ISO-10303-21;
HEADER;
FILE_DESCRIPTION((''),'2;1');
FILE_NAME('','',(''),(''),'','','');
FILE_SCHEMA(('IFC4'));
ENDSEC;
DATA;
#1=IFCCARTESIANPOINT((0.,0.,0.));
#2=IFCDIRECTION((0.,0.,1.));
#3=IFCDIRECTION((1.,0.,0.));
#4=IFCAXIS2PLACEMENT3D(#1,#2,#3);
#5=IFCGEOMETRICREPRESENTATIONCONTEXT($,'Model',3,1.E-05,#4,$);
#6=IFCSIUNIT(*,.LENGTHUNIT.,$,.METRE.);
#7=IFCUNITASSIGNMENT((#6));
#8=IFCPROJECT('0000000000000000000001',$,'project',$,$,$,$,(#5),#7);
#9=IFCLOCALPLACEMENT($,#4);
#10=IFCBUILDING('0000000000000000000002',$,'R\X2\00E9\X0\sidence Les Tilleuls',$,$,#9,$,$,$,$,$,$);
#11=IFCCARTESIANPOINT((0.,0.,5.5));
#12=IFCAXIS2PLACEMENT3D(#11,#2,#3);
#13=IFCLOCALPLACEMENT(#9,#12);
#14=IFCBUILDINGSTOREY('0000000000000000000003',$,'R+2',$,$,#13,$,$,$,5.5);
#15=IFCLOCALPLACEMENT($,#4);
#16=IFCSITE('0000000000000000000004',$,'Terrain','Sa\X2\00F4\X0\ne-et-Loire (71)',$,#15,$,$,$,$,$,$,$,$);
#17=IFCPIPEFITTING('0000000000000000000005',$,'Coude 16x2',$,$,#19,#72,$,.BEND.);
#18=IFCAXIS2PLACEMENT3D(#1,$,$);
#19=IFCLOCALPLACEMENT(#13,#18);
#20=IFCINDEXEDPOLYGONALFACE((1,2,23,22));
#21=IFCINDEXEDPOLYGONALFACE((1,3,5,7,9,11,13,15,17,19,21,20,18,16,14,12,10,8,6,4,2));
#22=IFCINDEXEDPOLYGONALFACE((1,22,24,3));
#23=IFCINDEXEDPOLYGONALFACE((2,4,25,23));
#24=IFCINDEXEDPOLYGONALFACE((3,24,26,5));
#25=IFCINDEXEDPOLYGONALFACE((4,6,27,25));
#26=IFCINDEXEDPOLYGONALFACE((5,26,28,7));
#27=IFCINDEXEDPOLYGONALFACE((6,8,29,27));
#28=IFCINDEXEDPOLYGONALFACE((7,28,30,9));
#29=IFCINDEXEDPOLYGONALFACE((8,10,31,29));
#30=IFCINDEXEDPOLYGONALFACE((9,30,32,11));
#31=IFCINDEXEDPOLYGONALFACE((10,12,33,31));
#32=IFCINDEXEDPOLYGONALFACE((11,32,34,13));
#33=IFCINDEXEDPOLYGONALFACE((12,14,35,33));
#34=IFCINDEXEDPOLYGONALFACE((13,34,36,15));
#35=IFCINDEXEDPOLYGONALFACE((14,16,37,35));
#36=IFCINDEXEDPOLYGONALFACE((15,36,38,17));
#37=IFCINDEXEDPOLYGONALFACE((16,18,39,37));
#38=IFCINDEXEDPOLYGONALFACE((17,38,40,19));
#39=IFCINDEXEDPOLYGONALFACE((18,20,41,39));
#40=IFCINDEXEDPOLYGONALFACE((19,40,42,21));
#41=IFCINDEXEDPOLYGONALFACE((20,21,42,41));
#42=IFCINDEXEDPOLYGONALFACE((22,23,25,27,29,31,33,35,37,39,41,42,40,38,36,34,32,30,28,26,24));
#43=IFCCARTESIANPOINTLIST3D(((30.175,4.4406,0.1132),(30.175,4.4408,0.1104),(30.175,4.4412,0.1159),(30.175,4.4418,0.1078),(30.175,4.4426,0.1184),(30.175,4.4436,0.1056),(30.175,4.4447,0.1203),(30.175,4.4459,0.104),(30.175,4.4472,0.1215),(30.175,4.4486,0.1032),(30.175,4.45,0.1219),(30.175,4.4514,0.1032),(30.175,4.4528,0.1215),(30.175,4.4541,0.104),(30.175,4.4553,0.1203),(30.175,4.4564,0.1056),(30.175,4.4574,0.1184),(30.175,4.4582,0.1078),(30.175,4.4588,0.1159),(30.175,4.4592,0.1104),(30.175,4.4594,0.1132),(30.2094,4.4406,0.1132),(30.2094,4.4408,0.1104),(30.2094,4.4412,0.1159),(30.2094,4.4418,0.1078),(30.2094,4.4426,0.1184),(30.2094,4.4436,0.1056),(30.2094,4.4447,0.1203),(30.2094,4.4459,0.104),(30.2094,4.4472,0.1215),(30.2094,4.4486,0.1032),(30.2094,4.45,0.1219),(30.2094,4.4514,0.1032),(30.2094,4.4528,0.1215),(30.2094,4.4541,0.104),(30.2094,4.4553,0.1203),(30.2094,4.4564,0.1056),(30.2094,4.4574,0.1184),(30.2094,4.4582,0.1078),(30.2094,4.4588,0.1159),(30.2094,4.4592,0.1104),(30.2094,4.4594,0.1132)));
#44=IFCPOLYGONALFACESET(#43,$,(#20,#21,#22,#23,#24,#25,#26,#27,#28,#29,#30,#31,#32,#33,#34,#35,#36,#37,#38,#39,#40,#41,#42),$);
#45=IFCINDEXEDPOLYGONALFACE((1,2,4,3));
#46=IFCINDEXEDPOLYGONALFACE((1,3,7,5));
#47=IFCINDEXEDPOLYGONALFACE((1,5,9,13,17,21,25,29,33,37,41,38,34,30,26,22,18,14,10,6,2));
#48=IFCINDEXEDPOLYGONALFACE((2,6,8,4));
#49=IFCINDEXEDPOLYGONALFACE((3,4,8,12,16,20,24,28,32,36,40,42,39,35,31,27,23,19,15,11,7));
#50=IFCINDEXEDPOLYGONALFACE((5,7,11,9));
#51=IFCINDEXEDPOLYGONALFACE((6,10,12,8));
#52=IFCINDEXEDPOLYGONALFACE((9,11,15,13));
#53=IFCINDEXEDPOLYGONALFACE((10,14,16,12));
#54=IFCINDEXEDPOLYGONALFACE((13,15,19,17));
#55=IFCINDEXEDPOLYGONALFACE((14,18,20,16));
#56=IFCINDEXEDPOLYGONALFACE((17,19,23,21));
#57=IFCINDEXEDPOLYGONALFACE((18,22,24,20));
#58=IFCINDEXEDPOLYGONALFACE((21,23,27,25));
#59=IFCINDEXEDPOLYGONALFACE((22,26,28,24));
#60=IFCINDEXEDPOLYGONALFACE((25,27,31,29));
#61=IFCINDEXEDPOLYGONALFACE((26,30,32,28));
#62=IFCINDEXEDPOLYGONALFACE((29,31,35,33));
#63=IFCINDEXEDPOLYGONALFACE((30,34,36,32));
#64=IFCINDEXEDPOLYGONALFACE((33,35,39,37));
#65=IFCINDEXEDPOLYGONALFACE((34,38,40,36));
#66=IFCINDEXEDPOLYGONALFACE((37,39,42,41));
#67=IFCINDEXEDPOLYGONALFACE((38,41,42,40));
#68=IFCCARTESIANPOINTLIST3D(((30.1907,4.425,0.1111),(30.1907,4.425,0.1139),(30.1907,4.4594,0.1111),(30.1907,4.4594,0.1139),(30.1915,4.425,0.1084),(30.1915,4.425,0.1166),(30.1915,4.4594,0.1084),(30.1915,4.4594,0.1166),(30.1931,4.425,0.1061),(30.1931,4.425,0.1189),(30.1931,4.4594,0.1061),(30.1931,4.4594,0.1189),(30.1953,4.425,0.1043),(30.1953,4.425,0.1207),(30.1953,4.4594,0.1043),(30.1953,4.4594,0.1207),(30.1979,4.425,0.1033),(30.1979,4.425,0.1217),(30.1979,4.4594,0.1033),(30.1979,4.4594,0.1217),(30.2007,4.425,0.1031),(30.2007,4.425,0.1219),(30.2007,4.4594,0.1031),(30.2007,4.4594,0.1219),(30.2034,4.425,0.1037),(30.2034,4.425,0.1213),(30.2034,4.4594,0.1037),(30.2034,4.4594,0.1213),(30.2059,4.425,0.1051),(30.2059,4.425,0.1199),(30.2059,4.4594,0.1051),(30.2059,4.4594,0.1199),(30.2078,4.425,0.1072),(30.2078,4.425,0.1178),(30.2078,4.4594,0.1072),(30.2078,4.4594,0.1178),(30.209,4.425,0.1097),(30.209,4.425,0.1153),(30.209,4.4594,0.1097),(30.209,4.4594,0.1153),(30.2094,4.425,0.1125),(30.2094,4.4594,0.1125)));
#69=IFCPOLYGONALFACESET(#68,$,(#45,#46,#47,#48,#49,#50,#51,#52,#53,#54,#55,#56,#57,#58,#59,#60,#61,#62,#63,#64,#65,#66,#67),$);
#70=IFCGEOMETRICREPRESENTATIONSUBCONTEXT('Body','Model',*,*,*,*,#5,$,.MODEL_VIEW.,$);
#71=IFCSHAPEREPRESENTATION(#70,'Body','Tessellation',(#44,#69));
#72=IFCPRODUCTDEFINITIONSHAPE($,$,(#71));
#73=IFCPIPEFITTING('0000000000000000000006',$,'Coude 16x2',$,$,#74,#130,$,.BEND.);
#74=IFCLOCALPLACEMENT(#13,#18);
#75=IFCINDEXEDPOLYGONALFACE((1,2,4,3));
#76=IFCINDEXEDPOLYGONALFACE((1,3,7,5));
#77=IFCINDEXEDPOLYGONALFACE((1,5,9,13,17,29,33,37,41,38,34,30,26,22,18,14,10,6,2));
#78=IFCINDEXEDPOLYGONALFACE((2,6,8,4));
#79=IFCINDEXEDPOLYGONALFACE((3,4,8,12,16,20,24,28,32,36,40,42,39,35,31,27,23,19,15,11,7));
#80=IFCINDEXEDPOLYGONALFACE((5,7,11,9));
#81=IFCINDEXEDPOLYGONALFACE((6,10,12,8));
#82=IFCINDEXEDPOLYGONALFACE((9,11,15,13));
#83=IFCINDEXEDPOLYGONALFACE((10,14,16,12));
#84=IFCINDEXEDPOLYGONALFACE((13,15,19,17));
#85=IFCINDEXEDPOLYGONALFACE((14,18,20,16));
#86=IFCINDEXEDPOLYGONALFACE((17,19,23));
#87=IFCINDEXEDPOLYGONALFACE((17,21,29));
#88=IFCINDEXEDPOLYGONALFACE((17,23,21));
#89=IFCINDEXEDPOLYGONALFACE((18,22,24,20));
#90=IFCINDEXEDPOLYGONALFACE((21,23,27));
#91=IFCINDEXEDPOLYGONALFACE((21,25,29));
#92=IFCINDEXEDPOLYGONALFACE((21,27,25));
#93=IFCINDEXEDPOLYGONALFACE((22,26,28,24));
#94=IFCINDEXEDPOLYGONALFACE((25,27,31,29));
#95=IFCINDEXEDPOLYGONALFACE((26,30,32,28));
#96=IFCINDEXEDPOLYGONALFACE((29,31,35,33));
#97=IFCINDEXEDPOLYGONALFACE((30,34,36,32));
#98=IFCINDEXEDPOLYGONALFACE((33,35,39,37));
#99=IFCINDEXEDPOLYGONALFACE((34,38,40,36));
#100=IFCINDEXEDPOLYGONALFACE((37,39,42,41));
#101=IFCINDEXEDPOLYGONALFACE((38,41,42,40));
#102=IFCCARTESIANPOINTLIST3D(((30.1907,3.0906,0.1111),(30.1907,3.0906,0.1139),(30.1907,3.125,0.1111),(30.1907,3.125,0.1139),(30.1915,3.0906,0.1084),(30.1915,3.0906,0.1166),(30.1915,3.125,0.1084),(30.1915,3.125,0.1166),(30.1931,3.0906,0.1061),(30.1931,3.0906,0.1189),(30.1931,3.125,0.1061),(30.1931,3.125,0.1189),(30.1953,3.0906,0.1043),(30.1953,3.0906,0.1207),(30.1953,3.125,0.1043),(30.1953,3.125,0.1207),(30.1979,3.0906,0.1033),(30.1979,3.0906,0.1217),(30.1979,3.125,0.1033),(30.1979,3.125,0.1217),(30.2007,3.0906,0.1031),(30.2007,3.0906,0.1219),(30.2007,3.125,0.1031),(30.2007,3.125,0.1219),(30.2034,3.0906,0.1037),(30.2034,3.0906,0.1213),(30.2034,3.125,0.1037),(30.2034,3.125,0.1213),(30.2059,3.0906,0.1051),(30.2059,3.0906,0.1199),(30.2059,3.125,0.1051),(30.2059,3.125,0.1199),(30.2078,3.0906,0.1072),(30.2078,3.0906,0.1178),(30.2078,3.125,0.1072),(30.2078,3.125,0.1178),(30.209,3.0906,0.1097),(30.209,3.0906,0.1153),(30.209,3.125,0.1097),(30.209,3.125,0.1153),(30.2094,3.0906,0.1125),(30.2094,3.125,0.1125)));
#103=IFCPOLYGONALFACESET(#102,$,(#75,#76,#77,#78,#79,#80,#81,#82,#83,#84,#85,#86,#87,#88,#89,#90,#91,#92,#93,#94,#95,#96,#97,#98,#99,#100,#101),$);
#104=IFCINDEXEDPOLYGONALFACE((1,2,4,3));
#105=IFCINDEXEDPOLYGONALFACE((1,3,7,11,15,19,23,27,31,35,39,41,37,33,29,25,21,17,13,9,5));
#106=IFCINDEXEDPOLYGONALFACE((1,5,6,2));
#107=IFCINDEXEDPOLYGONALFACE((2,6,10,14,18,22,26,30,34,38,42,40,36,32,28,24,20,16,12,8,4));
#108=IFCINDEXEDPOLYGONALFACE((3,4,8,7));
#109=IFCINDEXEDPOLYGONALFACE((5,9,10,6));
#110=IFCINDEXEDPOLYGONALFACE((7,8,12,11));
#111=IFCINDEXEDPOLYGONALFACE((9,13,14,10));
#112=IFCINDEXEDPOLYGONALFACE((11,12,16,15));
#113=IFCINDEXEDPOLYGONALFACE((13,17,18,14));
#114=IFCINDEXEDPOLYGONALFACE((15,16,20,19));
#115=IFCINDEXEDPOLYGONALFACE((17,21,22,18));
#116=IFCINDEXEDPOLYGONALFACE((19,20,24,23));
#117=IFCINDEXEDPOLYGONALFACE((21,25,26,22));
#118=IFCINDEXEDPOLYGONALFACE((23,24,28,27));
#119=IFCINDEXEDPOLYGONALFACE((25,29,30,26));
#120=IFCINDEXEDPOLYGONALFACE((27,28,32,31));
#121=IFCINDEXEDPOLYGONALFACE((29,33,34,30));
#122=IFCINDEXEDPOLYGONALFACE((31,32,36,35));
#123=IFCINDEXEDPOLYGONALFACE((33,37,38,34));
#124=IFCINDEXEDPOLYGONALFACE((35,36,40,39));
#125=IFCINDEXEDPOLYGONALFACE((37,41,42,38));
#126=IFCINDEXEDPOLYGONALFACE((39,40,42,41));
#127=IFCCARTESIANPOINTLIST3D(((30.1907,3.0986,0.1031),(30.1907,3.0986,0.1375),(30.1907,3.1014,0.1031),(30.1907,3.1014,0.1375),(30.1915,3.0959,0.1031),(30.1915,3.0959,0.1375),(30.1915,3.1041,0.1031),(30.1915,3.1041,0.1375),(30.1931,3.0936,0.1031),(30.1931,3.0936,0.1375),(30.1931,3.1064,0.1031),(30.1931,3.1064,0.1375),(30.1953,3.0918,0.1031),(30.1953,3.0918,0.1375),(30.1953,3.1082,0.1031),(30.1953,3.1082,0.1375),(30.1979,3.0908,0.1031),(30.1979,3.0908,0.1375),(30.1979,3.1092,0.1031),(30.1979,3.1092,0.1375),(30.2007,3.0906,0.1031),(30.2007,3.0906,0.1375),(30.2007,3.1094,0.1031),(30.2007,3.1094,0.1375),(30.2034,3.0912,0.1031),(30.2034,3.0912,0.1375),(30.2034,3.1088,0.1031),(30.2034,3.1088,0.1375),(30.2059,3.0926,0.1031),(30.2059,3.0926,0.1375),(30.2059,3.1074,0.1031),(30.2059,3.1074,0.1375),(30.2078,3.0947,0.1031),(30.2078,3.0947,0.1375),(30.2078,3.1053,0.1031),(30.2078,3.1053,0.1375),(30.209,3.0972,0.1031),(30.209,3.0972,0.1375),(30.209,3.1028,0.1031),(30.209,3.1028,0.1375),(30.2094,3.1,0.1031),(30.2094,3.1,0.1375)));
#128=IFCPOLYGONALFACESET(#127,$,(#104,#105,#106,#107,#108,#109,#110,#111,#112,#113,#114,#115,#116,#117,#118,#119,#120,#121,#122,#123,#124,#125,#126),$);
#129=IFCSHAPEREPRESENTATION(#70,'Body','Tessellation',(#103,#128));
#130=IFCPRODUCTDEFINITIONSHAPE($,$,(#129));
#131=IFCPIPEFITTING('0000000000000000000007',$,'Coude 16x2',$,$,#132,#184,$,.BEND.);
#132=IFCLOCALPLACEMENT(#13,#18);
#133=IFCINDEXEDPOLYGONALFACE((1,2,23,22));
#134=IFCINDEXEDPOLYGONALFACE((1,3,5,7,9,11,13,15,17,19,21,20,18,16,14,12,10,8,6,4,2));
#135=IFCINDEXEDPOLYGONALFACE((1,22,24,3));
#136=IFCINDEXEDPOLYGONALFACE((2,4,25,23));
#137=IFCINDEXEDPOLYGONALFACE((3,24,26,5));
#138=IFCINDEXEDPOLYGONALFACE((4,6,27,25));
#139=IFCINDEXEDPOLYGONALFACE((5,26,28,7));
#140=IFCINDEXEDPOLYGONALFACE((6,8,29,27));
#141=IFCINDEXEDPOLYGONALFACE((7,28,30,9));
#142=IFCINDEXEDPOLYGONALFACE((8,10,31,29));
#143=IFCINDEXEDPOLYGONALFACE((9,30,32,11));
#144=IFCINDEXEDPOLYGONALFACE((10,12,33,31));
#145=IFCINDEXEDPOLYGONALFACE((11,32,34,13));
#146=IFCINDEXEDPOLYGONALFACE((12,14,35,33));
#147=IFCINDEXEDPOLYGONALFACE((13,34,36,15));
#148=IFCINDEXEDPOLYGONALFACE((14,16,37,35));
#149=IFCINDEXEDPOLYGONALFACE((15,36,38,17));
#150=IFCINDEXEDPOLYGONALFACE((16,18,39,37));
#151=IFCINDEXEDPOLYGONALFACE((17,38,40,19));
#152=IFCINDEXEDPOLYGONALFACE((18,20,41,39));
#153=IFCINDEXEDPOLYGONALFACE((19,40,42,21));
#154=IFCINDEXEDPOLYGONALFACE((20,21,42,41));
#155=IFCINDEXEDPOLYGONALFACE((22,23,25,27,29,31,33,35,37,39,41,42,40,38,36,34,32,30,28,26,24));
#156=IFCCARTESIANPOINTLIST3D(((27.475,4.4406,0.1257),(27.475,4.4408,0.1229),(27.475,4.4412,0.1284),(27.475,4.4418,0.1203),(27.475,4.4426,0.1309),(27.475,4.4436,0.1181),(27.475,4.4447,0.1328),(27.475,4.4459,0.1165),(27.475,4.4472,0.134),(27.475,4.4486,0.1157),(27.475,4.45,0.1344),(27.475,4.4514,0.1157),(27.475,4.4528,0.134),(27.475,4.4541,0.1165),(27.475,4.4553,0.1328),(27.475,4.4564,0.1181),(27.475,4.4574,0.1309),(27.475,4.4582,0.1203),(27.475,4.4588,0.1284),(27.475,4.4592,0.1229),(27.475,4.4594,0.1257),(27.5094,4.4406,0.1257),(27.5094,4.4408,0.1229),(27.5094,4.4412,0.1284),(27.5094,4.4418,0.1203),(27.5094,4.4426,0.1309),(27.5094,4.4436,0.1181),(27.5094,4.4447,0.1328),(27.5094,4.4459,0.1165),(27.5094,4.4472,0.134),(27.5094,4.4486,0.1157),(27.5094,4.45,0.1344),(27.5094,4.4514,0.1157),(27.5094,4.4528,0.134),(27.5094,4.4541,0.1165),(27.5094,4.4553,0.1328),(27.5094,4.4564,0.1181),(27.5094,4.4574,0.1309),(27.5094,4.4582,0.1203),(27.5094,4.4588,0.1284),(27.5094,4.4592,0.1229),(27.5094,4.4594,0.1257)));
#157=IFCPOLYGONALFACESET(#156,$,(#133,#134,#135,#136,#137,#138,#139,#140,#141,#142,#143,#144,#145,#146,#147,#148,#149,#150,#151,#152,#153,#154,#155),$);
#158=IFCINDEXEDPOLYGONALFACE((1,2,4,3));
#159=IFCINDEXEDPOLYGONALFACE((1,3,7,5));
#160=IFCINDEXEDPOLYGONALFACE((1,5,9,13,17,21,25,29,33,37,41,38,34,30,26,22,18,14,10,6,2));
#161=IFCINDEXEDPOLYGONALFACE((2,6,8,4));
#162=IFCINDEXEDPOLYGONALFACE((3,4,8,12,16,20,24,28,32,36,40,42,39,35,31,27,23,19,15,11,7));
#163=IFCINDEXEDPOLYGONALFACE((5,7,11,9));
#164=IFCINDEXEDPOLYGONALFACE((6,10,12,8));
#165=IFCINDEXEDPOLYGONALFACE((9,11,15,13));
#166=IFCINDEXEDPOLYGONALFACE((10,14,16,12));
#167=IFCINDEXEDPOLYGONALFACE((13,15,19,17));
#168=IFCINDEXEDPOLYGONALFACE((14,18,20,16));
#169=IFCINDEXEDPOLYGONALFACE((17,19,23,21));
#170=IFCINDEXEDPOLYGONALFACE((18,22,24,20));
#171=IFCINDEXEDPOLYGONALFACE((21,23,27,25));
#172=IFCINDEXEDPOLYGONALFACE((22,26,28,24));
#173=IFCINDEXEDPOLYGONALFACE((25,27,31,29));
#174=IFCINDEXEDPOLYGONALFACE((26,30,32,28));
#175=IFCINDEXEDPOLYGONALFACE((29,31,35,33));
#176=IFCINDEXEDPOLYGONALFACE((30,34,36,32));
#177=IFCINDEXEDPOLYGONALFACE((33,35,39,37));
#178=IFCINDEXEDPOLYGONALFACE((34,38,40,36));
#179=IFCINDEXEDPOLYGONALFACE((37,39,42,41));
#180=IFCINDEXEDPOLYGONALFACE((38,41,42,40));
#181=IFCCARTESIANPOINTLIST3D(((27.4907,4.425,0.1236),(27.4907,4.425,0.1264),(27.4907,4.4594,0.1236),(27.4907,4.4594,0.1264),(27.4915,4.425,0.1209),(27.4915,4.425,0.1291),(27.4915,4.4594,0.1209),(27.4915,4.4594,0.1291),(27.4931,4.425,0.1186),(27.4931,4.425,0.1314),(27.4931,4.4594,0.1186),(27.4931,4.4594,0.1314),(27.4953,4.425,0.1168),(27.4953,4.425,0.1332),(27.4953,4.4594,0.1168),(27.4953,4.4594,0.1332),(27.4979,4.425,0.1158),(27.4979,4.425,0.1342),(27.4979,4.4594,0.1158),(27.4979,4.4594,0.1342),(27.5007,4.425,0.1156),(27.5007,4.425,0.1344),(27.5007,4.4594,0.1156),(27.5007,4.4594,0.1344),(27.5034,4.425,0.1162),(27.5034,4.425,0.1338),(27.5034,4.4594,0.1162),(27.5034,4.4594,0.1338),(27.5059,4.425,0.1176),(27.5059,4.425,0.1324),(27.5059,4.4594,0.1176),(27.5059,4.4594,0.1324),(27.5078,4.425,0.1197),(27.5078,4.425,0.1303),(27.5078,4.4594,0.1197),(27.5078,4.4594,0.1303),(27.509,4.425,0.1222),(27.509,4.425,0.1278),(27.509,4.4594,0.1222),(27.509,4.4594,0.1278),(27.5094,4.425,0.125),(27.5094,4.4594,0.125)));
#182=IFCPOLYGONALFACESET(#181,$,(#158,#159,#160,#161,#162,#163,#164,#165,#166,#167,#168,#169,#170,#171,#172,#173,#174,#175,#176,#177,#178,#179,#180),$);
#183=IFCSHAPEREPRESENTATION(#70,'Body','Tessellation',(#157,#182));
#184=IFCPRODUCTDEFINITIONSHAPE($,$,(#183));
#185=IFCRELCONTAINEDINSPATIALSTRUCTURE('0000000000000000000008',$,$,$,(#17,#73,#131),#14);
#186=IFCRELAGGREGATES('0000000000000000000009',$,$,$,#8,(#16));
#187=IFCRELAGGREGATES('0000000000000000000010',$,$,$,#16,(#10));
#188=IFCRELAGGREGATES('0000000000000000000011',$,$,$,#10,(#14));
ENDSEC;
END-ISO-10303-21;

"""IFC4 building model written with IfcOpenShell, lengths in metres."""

from ifc_helpers import new_model, si_unit, frame, origin_with_axes, place, context, subcontext, project, spatial, circle, extrude, element, save


model = new_model("IFC4")

# Units and contexts
model_context = context("Model", 3, precision=1e-05, world=origin_with_axes())
body_context = subcontext(model_context, "Body", "Model", "MODEL_VIEW")
ifc_project = project(units=[si_unit("LENGTHUNIT", "METRE")], contexts=[model_context])

# Site, building, storey
site_placement = place(None, origin_with_axes())
site = spatial("IfcSite", under=ifc_project, at=site_placement, Name="Terrain", Description="Saône-et-Loire (71)")
building_placement = place(None, origin_with_axes())
building = spatial("IfcBuilding", under=site, at=building_placement, Name="Résidence Les Tilleuls")
storey_placement = place(building_placement, frame((0.0, 0.0, 5.5), z_axis=(0.0, 0.0, 1.0), x_axis=(1.0, 0.0, 0.0)))
storey = spatial("IfcBuildingStorey", under=building, at=storey_placement, Name="R+2", Elevation=5.5)

# Pipe fittings
pipe_fitting_1_placement = place(storey_placement, frame((30.2, 4.45, 0.1125), z_axis=(0.0, 0.0, 1.0), x_axis=(1.0, 0.0, 0.0)))
element("IfcPipeFitting", 1, at=pipe_fitting_1_placement, inside=storey, Name="Coude 16x2", PredefinedType="BEND", context=body_context, shape_type="SweptSolid", body=[
    extrude(circle(Radius=0.0094), frame((0.0094, 0.0, 0.0), z_axis=(-1.0, 0.0, 0.0), x_axis=(0.0, 0.0, 1.0)), (0.0, 0.0, 1.0), 0.0344),
    extrude(circle(Radius=0.0094), frame((0.0, 0.0094, 0.0), z_axis=(0.0, -1.0, 0.0), x_axis=(1.0, 0.0, 0.0)), (0.0, 0.0, 1.0), 0.0344),
])
pipe_fitting_2_placement = place(storey_placement, frame((30.2, 3.1, 0.1125), z_axis=(0.0, 0.0, 1.0), x_axis=(1.0, 0.0, 0.0)))
element("IfcPipeFitting", 2, at=pipe_fitting_2_placement, inside=storey, Name="Coude 16x2", PredefinedType="BEND", context=body_context, shape_type="SweptSolid", body=[
    extrude(circle(Radius=0.0094), frame((0.0, -0.0094, 0.0), z_axis=(0.0, 1.0, 0.0), x_axis=(1.0, 0.0, 0.0)), (0.0, 0.0, 1.0), 0.0344),
    extrude(circle(Radius=0.0094), frame((0.0, 0.0, -0.0094), z_axis=(0.0, 0.0, 1.0), x_axis=(1.0, 0.0, 0.0)), (0.0, 0.0, 1.0), 0.0344),
])
pipe_fitting_3_placement = place(storey_placement, frame((27.5, 4.45, 0.125), z_axis=(0.0, 0.0, 1.0), x_axis=(1.0, 0.0, 0.0)))
element("IfcPipeFitting", 3, at=pipe_fitting_3_placement, inside=storey, Name="Coude 16x2", PredefinedType="BEND", context=body_context, shape_type="SweptSolid", body=[
    extrude(circle(Radius=0.0094), frame((0.0094, 0.0, 0.0), z_axis=(-1.0, 0.0, 0.0), x_axis=(0.0, 0.0, 1.0)), (0.0, 0.0, 1.0), 0.0344),
    extrude(circle(Radius=0.0094), frame((0.0, 0.0094, 0.0), z_axis=(0.0, -1.0, 0.0), x_axis=(1.0, 0.0, 0.0)), (0.0, 0.0, 1.0), 0.0344),
])

save(model, "model.ifc")
